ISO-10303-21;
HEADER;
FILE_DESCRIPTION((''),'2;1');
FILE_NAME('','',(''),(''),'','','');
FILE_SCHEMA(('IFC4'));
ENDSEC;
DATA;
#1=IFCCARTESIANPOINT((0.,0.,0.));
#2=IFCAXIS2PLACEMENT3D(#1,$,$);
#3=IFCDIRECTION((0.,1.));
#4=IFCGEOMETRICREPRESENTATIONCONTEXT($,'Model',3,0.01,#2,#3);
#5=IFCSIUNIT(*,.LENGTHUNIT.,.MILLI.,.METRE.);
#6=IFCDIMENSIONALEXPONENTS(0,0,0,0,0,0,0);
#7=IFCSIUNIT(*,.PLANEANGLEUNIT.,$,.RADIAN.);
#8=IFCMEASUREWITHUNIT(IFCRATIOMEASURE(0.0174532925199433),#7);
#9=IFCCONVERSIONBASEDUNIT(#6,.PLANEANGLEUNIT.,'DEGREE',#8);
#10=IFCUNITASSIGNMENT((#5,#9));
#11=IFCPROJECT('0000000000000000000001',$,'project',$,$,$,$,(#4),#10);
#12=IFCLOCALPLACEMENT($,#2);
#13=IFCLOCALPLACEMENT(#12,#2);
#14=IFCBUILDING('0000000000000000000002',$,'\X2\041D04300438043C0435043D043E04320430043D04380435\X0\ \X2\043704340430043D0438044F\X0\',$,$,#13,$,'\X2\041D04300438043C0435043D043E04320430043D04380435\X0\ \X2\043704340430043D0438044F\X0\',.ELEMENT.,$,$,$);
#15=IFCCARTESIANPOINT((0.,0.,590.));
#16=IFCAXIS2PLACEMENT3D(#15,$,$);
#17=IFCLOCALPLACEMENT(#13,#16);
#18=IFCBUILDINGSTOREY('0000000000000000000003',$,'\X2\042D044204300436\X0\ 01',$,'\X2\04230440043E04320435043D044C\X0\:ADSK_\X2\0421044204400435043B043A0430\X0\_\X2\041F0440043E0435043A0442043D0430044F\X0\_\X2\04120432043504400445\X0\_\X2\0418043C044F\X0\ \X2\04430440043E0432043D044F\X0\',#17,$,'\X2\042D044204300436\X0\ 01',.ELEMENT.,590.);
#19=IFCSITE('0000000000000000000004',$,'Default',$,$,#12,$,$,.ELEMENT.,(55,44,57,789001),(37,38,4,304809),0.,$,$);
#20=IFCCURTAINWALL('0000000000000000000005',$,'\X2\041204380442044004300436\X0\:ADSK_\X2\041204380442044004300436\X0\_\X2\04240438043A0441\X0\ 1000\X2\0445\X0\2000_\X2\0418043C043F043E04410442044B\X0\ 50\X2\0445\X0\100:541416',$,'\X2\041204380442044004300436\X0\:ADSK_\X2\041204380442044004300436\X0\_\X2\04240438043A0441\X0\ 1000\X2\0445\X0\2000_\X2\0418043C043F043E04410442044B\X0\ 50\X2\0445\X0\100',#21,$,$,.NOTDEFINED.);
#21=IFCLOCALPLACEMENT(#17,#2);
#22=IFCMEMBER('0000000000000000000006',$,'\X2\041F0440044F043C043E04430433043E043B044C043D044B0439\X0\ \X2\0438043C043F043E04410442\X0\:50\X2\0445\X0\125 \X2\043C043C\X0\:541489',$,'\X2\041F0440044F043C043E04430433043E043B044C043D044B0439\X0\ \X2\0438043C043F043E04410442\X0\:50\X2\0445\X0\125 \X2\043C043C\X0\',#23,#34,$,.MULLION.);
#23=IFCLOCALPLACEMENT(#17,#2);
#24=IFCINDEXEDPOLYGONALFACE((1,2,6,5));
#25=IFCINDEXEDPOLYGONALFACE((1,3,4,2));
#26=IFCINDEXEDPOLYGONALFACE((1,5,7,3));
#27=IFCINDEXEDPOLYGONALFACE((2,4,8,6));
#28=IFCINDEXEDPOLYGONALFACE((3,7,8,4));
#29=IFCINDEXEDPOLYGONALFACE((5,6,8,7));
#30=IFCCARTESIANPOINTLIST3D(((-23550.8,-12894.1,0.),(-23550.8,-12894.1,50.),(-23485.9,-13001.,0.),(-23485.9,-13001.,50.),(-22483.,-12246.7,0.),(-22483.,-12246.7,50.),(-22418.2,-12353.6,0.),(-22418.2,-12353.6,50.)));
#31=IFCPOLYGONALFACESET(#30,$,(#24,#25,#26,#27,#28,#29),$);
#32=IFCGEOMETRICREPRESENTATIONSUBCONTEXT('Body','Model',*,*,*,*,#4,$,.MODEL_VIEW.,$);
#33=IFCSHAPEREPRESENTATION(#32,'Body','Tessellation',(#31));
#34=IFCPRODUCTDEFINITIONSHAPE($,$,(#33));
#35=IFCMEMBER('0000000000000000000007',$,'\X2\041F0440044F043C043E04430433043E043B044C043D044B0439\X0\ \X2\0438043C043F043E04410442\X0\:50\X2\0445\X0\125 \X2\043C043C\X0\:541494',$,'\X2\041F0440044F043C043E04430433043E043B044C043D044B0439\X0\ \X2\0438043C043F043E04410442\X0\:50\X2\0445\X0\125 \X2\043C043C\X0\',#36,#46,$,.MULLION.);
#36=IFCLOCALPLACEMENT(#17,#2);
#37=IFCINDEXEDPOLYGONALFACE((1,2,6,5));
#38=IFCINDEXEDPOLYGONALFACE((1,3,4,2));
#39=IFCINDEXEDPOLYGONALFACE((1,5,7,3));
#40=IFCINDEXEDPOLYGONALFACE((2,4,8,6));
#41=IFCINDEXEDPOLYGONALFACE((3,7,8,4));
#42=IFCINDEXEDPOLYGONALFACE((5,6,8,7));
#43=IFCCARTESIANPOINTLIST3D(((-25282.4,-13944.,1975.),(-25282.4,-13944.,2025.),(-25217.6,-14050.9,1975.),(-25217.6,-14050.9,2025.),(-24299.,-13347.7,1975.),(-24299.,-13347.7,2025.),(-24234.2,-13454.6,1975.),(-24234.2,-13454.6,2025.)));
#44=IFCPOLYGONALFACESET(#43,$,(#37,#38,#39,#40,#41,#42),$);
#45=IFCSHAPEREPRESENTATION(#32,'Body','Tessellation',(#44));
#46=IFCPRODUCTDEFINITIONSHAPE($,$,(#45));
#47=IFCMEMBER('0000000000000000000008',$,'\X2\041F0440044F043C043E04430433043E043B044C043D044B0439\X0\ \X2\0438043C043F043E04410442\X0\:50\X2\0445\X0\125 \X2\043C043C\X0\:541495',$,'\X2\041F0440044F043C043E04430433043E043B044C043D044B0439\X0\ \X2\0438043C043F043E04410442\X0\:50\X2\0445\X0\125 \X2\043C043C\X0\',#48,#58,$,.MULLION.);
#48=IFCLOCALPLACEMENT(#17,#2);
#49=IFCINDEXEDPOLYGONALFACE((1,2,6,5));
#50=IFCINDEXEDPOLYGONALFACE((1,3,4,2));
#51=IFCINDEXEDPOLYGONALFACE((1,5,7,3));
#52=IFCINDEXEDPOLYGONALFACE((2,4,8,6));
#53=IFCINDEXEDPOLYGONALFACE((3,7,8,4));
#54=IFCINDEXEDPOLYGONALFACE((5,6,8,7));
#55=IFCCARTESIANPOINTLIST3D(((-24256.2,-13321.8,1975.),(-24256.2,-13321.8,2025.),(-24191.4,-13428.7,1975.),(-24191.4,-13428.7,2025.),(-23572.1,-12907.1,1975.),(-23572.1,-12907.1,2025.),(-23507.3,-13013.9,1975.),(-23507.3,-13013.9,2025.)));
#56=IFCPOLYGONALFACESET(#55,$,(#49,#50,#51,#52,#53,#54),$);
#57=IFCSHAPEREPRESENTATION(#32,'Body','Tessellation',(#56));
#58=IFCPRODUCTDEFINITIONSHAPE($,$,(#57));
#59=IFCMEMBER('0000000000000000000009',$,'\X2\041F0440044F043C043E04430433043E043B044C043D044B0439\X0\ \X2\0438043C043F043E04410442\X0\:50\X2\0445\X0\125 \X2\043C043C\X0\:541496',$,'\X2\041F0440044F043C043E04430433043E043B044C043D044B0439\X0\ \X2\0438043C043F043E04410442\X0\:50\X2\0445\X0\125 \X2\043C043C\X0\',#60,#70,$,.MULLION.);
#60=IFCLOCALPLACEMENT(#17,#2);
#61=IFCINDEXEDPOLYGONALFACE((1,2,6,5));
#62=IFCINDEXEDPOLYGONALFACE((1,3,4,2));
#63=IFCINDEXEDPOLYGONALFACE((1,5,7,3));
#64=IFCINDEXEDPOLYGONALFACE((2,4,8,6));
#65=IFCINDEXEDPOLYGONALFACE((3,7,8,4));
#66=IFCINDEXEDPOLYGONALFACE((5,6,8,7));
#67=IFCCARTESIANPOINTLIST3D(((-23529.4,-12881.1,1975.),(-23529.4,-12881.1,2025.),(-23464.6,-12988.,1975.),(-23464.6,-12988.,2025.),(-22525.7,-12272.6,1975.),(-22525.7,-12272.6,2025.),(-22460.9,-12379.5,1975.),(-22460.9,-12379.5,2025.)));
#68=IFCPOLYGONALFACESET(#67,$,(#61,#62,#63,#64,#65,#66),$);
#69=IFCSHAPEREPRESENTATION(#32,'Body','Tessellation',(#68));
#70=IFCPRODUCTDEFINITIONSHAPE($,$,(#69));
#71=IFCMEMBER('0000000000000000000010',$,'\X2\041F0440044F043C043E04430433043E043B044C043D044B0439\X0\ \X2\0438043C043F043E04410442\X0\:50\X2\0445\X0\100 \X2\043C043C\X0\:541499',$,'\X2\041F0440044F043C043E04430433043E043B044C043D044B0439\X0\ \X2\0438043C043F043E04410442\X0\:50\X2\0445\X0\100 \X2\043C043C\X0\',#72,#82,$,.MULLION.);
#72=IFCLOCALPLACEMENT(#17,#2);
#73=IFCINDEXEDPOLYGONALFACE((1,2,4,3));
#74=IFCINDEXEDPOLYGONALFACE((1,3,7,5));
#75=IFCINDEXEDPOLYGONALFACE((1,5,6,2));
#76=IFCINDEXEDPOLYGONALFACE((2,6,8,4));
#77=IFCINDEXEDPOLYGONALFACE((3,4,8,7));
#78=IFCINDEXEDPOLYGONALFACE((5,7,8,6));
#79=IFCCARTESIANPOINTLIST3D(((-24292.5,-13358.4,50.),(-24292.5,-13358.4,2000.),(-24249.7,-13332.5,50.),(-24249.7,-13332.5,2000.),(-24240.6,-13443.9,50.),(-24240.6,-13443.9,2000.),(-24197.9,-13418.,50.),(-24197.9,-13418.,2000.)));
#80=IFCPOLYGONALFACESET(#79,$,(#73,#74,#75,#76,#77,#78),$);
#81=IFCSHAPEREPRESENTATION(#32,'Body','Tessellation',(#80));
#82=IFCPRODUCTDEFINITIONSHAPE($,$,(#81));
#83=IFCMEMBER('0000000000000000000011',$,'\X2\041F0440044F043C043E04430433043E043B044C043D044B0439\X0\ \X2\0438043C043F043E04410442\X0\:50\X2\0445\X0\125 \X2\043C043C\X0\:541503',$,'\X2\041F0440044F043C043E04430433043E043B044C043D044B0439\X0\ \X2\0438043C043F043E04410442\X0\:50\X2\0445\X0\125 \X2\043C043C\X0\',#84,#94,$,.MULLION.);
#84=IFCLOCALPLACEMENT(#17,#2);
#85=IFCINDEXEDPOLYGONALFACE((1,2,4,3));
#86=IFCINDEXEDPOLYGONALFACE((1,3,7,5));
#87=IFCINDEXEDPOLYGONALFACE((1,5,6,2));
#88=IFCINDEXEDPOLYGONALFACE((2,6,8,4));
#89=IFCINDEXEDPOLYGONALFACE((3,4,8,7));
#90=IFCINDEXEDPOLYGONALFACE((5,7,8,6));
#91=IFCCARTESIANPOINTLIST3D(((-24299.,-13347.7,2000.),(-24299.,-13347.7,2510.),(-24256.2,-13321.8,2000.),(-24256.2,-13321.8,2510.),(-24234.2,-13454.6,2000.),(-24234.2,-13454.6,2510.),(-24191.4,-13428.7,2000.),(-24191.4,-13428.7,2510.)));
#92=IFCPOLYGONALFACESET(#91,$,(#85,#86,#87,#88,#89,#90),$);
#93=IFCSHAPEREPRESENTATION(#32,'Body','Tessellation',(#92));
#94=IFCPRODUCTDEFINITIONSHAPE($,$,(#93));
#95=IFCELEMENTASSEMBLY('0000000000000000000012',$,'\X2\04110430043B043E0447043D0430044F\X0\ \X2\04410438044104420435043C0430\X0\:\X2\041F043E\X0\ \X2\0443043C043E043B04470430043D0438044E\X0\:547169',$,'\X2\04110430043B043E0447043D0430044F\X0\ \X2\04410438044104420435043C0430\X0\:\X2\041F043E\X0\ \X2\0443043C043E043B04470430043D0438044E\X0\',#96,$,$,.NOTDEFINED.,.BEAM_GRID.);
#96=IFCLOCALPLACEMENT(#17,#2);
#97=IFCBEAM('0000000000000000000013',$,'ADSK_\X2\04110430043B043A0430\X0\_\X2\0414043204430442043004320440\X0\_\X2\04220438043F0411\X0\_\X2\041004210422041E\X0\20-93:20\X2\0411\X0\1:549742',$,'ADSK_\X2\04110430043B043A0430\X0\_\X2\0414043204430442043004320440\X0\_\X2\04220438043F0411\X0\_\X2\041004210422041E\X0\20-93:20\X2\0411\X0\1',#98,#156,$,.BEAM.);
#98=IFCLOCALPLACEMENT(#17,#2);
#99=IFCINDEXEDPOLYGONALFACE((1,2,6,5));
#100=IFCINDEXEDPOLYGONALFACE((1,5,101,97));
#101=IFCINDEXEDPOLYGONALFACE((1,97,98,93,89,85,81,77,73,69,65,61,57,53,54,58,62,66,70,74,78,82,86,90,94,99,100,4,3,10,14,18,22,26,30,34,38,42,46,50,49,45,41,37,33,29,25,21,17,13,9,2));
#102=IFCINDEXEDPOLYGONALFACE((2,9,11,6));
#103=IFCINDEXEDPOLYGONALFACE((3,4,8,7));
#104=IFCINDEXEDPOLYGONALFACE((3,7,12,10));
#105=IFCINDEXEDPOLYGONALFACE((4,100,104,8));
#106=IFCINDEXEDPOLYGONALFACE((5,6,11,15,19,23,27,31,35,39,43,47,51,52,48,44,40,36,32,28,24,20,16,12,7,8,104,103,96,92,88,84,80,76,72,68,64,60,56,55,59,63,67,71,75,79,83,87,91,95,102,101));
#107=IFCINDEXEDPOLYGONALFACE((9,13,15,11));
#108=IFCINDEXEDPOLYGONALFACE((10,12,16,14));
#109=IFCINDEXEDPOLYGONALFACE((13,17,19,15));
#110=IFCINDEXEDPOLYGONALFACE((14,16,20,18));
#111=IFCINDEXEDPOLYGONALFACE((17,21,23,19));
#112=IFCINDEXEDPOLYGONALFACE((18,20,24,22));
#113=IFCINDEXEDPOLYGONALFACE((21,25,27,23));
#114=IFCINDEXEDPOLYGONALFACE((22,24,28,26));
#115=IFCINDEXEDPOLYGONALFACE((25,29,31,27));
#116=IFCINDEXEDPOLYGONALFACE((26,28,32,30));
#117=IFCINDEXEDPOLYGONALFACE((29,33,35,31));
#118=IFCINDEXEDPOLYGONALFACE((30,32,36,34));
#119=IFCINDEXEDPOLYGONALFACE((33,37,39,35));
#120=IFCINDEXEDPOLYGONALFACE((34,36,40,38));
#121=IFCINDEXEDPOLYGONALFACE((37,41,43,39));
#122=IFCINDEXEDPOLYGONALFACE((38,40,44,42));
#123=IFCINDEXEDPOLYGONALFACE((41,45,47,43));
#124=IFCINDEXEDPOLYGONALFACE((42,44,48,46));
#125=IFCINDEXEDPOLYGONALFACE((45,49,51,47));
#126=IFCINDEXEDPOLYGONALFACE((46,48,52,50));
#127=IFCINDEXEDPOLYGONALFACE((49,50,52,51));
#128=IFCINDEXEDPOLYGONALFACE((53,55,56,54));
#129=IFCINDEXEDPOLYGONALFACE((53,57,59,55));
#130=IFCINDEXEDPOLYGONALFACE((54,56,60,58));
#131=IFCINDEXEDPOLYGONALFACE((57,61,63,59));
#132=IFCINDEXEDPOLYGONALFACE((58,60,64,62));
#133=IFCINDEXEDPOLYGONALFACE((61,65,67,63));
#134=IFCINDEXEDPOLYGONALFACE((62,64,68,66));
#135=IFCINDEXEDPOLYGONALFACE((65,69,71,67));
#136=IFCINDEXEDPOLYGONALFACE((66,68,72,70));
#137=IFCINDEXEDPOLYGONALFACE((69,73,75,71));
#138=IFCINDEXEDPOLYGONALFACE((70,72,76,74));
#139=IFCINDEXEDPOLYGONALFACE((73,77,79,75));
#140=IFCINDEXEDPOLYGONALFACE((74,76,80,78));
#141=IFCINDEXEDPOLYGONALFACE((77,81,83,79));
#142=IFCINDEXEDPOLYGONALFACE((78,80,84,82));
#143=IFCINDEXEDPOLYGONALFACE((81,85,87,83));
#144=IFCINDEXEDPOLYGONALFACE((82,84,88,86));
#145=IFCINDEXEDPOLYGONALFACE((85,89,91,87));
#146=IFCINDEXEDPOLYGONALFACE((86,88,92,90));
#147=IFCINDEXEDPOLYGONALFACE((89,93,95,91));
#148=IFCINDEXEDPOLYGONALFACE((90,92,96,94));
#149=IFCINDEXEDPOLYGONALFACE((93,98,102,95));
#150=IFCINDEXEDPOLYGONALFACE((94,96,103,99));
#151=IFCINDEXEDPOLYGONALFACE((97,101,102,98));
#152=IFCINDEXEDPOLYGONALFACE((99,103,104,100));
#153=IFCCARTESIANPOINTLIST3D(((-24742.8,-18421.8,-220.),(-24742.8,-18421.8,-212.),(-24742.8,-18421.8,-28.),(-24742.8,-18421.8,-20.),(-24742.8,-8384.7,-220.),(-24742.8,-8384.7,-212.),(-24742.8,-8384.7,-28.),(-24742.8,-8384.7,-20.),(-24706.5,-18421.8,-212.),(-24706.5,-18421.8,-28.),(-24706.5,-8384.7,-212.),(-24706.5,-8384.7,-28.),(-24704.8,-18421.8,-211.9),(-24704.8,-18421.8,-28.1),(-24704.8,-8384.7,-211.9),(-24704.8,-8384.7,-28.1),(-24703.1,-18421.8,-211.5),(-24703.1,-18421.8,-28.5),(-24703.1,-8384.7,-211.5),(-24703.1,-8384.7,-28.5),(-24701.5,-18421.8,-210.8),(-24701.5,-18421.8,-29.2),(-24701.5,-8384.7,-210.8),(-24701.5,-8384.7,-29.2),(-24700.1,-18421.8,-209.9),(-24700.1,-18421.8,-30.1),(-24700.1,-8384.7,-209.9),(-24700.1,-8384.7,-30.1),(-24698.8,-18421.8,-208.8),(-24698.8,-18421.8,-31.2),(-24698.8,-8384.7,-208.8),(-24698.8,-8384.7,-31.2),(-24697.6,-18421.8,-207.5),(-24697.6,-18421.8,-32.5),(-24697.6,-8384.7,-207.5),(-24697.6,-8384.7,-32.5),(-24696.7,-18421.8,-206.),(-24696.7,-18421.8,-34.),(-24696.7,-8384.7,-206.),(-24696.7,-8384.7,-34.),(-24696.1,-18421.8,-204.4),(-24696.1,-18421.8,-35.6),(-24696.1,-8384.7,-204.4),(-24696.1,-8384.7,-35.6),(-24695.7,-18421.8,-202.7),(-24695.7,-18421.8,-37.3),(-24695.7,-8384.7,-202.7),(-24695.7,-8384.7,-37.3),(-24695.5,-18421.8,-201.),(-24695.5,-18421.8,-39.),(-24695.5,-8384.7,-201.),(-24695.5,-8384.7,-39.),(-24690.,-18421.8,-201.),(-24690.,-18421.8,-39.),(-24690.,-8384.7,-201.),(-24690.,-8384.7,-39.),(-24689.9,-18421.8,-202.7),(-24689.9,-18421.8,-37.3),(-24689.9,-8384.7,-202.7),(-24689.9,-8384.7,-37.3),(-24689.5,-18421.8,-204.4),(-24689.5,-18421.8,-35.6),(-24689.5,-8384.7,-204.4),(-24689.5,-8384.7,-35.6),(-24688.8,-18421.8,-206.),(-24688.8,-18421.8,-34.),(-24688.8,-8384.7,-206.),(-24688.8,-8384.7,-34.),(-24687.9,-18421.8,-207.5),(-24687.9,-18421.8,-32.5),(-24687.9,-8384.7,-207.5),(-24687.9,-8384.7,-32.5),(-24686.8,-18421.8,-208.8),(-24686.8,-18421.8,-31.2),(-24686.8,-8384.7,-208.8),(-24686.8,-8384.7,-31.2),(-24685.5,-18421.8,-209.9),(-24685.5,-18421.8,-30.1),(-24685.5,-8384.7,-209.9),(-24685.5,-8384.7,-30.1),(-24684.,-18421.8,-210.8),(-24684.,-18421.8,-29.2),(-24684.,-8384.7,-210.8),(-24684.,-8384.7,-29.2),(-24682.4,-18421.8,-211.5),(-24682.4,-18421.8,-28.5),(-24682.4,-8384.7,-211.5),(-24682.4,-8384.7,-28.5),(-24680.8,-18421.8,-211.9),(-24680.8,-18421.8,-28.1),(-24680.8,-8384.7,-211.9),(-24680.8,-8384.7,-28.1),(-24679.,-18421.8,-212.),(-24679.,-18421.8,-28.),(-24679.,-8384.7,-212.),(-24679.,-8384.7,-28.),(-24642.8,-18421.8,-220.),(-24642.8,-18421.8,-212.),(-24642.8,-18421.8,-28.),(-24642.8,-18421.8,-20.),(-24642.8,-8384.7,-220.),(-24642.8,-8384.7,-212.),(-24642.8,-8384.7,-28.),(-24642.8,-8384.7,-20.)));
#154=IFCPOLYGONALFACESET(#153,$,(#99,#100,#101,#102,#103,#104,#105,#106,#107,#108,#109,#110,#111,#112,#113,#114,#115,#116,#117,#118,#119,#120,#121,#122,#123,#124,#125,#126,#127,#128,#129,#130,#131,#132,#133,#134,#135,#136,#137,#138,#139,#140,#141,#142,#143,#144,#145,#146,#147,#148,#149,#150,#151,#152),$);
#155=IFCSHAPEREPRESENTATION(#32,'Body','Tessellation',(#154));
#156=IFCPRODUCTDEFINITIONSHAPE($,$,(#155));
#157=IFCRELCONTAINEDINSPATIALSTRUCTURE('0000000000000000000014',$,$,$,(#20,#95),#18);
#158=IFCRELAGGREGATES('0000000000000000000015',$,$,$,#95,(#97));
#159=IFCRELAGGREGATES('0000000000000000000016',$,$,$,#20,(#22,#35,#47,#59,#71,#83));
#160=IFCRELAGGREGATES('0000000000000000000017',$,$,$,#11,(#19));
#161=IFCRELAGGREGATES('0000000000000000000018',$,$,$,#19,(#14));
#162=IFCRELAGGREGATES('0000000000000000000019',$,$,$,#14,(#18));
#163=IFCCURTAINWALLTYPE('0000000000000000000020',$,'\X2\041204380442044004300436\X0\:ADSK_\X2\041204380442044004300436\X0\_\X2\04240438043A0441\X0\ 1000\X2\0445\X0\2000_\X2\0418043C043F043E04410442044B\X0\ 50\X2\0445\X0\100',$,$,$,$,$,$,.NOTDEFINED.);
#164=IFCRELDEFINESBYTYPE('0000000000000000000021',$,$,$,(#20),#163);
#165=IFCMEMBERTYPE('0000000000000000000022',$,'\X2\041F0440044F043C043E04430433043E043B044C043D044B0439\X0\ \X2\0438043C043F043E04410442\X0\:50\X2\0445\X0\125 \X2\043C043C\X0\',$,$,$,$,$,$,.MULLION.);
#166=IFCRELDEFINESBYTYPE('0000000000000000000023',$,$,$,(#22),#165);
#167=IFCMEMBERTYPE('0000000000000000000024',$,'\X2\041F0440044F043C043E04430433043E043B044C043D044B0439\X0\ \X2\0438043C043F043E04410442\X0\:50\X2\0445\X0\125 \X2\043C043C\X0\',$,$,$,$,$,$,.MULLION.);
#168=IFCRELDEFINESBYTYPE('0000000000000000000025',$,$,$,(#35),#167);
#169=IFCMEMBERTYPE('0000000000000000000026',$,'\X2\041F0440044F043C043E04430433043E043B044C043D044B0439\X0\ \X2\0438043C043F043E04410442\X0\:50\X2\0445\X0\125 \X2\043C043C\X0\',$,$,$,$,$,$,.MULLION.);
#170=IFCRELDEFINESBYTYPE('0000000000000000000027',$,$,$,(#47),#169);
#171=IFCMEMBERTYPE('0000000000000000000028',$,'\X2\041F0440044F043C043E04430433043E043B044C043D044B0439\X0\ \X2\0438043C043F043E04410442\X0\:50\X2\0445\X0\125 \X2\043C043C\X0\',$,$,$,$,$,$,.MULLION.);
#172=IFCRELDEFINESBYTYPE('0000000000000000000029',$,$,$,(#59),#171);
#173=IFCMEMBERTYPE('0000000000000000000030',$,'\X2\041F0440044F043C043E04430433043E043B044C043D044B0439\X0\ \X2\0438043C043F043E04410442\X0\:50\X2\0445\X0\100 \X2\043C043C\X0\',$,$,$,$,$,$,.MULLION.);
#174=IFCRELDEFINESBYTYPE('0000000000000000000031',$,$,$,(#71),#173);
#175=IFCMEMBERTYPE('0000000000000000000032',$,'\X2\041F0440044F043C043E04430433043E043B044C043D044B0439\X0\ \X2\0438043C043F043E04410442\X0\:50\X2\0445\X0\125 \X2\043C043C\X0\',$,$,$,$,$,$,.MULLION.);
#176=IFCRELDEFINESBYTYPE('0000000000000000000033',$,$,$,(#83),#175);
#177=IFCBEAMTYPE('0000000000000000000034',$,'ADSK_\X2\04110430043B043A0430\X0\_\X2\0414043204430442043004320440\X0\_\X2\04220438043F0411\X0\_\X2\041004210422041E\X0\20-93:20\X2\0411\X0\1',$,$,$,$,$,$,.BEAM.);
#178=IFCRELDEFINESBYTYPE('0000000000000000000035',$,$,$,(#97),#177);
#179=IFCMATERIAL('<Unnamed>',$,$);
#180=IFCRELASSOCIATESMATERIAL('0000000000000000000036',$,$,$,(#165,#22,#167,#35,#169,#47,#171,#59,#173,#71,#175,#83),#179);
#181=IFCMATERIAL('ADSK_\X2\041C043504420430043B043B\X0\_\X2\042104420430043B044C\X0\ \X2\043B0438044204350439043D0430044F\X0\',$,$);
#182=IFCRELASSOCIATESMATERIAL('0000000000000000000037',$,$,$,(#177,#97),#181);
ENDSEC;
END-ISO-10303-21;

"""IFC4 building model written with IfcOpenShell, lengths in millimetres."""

from ifc_helpers import new_model, entity, si_unit, converted_unit, direction, frame, origin, place, context, subcontext, project, spatial, indexed_curve, outline, extrude, source, transform, mapped, material, type_object, type_shapes, element, aggregate, save


model = new_model("IFC4")

# Units and contexts
model_context = context("Model", 3, precision=0.01, world=origin(), true_north=direction((0.0, 1.0)))
body_context = subcontext(model_context, "Body", "Model", "MODEL_VIEW")
ifc_project = project(units=[si_unit("LENGTHUNIT", "METRE", prefix="MILLI"), converted_unit("PLANEANGLEUNIT", "DEGREE", entity("IfcRatioMeasure", 0.0174532925199433), si_unit("PLANEANGLEUNIT", "RADIAN"), dimensions=[0, 0, 0, 0, 0, 0, 0])], contexts=[model_context])

# Site, building, storey
site_placement = place(None, origin())
site = spatial("IfcSite", under=ifc_project, at=site_placement, Name="Default", CompositionType="ELEMENT", RefLatitude=(55, 44, 57, 789001), RefLongitude=(37, 38, 4, 304809), RefElevation=0.0)
building_placement = place(site_placement, origin())
building = spatial("IfcBuilding", under=site, at=building_placement, Name="Наименование здания", LongName="Наименование здания", CompositionType="ELEMENT")
storey_placement = place(building_placement, frame((0.0, 0.0, 590.0)))
storey = spatial("IfcBuildingStorey", under=building, at=storey_placement, Name="Этаж 01", ObjectType="Уровень:ADSK_Стрелка_Проектная_Вверх_Имя уровня", LongName="Этаж 01", CompositionType="ELEMENT", Elevation=590.0)

# Curtain wall, members
curtain_wall_type = type_object("IfcCurtainWallType", Name="Витраж:ADSK_Витраж_Фикс 1000х2000_Импосты 50х100", PredefinedType="NOTDEFINED")
curtain_wall_placement = place(storey_placement, frame((0.0, 0.0, -590.0)))
curtain_wall = element("IfcCurtainWall", 1, at=curtain_wall_placement, inside=storey, type_object=curtain_wall_type, Name="Витраж:ADSK_Витраж_Фикс 1000х2000_Импосты 50х100:541416", ObjectType="Витраж:ADSK_Витраж_Фикс 1000х2000_Импосты 50х100", PredefinedType="NOTDEFINED")
ifc_material_1 = material(Name="<Unnamed>")
member_type_1 = type_object("IfcMemberType", Name="Прямоугольный импост:50х125 мм", PredefinedType="MULLION", material=ifc_material_1)
shared_shape_1 = source(origin(), body_context, "Body", "SweptSolid", [
    extrude(outline(indexed_curve([(-62.5, -25.0), (62.5, -25.0), (62.5, 25.0), (-62.5, 25.0), (-62.5, -25.0)], self_intersect=False)), frame((-25.0, 0.0, -1248.7), z_axis=(0.0, 0.0, 1.0), x_axis=(0.0, -1.0, 0.0)), (0.0, 0.0, 1.0), 1248.7),
])
type_shapes(member_type_1, [shared_shape_1])
member_1_placement = place(storey_placement, frame((-23518.4, -12947.5, 0.0), z_axis=(-0.855102, -0.51846, 0.0), x_axis=(0.0, 0.0, -1.0)))
member_1 = element("IfcMember", 2, at=member_1_placement, type_object=member_type_1, material=ifc_material_1, Name="Прямоугольный импост:50х125 мм:541489", ObjectType="Прямоугольный импост:50х125 мм", PredefinedType="MULLION", context=body_context, shape_type="MappedRepresentation", body=[
    mapped(shared_shape_1, transform((0.0, 0.0, 0.0), scale=1.0)),
])
member_type_2 = type_object("IfcMemberType", Name="Прямоугольный импост:50х125 мм", PredefinedType="MULLION", material=ifc_material_1)
shared_shape_2 = source(origin(), body_context, "Body", "SweptSolid", [
    extrude(outline(indexed_curve([(-62.5, -25.0), (62.5, -25.0), (62.5, 25.0), (-62.5, 25.0), (-62.5, -25.0)], self_intersect=False)), frame((0.0, 0.0, -1150.1), z_axis=(0.0, 0.0, 1.0), x_axis=(0.0, -1.0, 0.0)), (0.0, 0.0, 1.0), 1150.1),
])
type_shapes(member_type_2, [shared_shape_2])
member_2_placement = place(storey_placement, frame((-24266.6, -13401.2, 2000.0), z_axis=(0.855102, 0.51846, 0.0), x_axis=(0.0, 0.0, 1.0)))
member_2 = element("IfcMember", 3, at=member_2_placement, type_object=member_type_2, material=ifc_material_1, Name="Прямоугольный импост:50х125 мм:541494", ObjectType="Прямоугольный импост:50х125 мм", PredefinedType="MULLION", context=body_context, shape_type="MappedRepresentation", body=[
    mapped(shared_shape_2, transform((0.0, 0.0, 0.0), scale=1.0)),
])
member_type_3 = type_object("IfcMemberType", Name="Прямоугольный импост:50х125 мм", PredefinedType="MULLION", material=ifc_material_1)
shared_shape_3 = source(origin(), body_context, "Body", "SweptSolid", [
    extrude(outline(indexed_curve([(-62.5, -25.0), (62.5, -25.0), (62.5, 25.0), (-62.5, 25.0), (-62.5, -25.0)], self_intersect=False)), frame((0.0, 0.0, -800.0), z_axis=(0.0, 0.0, 1.0), x_axis=(0.0, -1.0, 0.0)), (0.0, 0.0, 1.0), 800.0),
])
type_shapes(member_type_3, [shared_shape_3])
member_3_placement = place(storey_placement, frame((-23539.7, -12960.5, 2000.0), z_axis=(0.855102, 0.51846, 0.0), x_axis=(0.0, 0.0, 1.0)))
member_3 = element("IfcMember", 4, at=member_3_placement, type_object=member_type_3, material=ifc_material_1, Name="Прямоугольный импост:50х125 мм:541495", ObjectType="Прямоугольный импост:50х125 мм", PredefinedType="MULLION", context=body_context, shape_type="MappedRepresentation", body=[
    mapped(shared_shape_3, transform((0.0, 0.0, 0.0), scale=1.0)),
])
member_type_4 = type_object("IfcMemberType", Name="Прямоугольный импост:50х125 мм", PredefinedType="MULLION", material=ifc_material_1)
shared_shape_4 = source(origin(), body_context, "Body", "SweptSolid", [
    extrude(outline(indexed_curve([(-62.5, -25.0), (62.5, -25.0), (62.5, 25.0), (-62.5, 25.0), (-62.5, -25.0)], self_intersect=False)), frame((0.0, 0.0, -1173.7), z_axis=(0.0, 0.0, 1.0), x_axis=(0.0, -1.0, 0.0)), (0.0, 0.0, 1.0), 1173.7),
])
type_shapes(member_type_4, [shared_shape_4])
member_4_placement = place(storey_placement, frame((-22493.3, -12326.1, 2000.0), z_axis=(0.855102, 0.51846, 0.0), x_axis=(0.0, 0.0, 1.0)))
member_4 = element("IfcMember", 5, at=member_4_placement, type_object=member_type_4, material=ifc_material_1, Name="Прямоугольный импост:50х125 мм:541496", ObjectType="Прямоугольный импост:50х125 мм", PredefinedType="MULLION", context=body_context, shape_type="MappedRepresentation", body=[
    mapped(shared_shape_4, transform((0.0, 0.0, 0.0), scale=1.0)),
])
member_type_5 = type_object("IfcMemberType", Name="Прямоугольный импост:50х100 мм", PredefinedType="MULLION", material=ifc_material_1)
shared_shape_5 = source(origin(), body_context, "Body", "SweptSolid", [
    extrude(outline(indexed_curve([(-50.0, -25.0), (50.0, -25.0), (50.0, 25.0), (-50.0, 25.0), (-50.0, -25.0)], self_intersect=False)), frame((0.0, 0.0, -1950.0), z_axis=(0.0, 0.0, 1.0), x_axis=(0.0, -1.0, 0.0)), (0.0, 0.0, 1.0), 1950.0),
])
type_shapes(member_type_5, [shared_shape_5])
member_5_placement = place(storey_placement, frame((-24245.2, -13388.2, 50.0), z_axis=(0.0, 0.0, -1.0), x_axis=(0.855102, 0.51846, 0.0)))
member_5 = element("IfcMember", 6, at=member_5_placement, type_object=member_type_5, material=ifc_material_1, Name="Прямоугольный импост:50х100 мм:541499", ObjectType="Прямоугольный импост:50х100 мм", PredefinedType="MULLION", context=body_context, shape_type="MappedRepresentation", body=[
    mapped(shared_shape_5, transform((0.0, 0.0, 0.0), scale=1.0)),
])
member_type_6 = type_object("IfcMemberType", Name="Прямоугольный импост:50х125 мм", PredefinedType="MULLION", material=ifc_material_1)
shared_shape_6 = source(origin(), body_context, "Body", "SweptSolid", [
    extrude(outline(indexed_curve([(-62.5, -25.0), (62.5, -25.0), (62.5, 25.0), (-62.5, 25.0), (-62.5, -25.0)], self_intersect=False)), frame((0.0, 0.0, -510.0), z_axis=(0.0, 0.0, 1.0), x_axis=(0.0, -1.0, 0.0)), (0.0, 0.0, 1.0), 510.0),
])
type_shapes(member_type_6, [shared_shape_6])
member_6_placement = place(storey_placement, frame((-24245.2, -13388.2, 2000.0), z_axis=(0.0, 0.0, -1.0), x_axis=(0.855102, 0.51846, 0.0)))
member_6 = element("IfcMember", 7, at=member_6_placement, type_object=member_type_6, material=ifc_material_1, Name="Прямоугольный импост:50х125 мм:541503", ObjectType="Прямоугольный импост:50х125 мм", PredefinedType="MULLION", context=body_context, shape_type="MappedRepresentation", body=[
    mapped(shared_shape_6, transform((0.0, 0.0, 0.0), scale=1.0)),
])

# Element assembly, beam
assembly_placement = place(storey_placement, origin())
assembly = element("IfcElementAssembly", 8, at=assembly_placement, inside=storey, Name="Балочная система:По умолчанию:547169", ObjectType="Балочная система:По умолчанию", AssemblyPlace="NOTDEFINED", PredefinedType="BEAM_GRID")
ifc_material_2 = material(Name="ADSK_Металл_Сталь литейная")
beam_type_1 = type_object("IfcBeamType", Name="ADSK_Балка_Двутавр_ТипБ_АСТО20-93:20Б1", PredefinedType="BEAM", material=ifc_material_2)
shared_shape_7 = source(origin(), body_context, "Body", "SweptSolid", [
    extrude(outline(indexed_curve([(-100.0, -50.0), (-92.0, -50.0), (-92.0, -13.8), (-91.9, -12.0), (-91.5, -10.4), (-90.8, -8.8), (-89.9, -7.3), (-88.8, -6.0), (-87.5, -4.9), (-86.0, -3.9), (-84.4, -3.3), (-82.7, -2.9), (-81.0, -2.8), (81.0, -2.8), (82.7, -2.9), (84.4, -3.3), (86.0, -3.9), (87.5, -4.9), (88.8, -6.0), (89.9, -7.3), (90.8, -8.8), (91.5, -10.4), (91.9, -12.0), (92.0, -13.7), (92.0, -50.0), (100.0, -50.0), (100.0, 50.0), (92.0, 50.0), (92.0, 13.8), (91.9, 12.0), (91.5, 10.4), (90.8, 8.8), (89.9, 7.3), (88.8, 6.0), (87.5, 4.9), (86.0, 3.9), (84.4, 3.3), (82.7, 2.9), (81.0, 2.8), (-81.0, 2.8), (-82.7, 2.9), (-84.4, 3.3), (-86.0, 3.9), (-87.5, 4.9), (-88.8, 6.0), (-89.9, 7.3), (-90.8, 8.8), (-91.5, 10.4), (-91.9, 12.0), (-92.0, 13.8), (-92.0, 50.0), (-100.0, 50.0), (-100.0, -50.0)], self_intersect=False)), frame((-5018.6, 0.0, -100.0), z_axis=(1.0, 0.0, 0.0), x_axis=(0.0, 0.0, -1.0)), (0.0, 0.0, 1.0), 10037.1),
])
type_shapes(beam_type_1, [shared_shape_7])
beam_1_placement = place(assembly_placement, frame((-24692.8, -13403.2, -20.0), z_axis=(0.0, 0.0, 1.0), x_axis=(0.0, 1.0, 0.0)))
beam_1 = element("IfcBeam", 9, at=beam_1_placement, type_object=beam_type_1, material=ifc_material_2, Name="ADSK_Балка_Двутавр_ТипБ_АСТО20-93:20Б1:549742", ObjectType="ADSK_Балка_Двутавр_ТипБ_АСТО20-93:20Б1", PredefinedType="BEAM", context=body_context, shape_type="MappedRepresentation", body=[
    mapped(shared_shape_7, transform((0.0, 0.0, 0.0), scale=1.0)),
])
aggregate(assembly, [beam_1])

aggregate(curtain_wall, [member_1, member_2, member_3, member_4, member_5, member_6])

save(model, "model.ifc")
